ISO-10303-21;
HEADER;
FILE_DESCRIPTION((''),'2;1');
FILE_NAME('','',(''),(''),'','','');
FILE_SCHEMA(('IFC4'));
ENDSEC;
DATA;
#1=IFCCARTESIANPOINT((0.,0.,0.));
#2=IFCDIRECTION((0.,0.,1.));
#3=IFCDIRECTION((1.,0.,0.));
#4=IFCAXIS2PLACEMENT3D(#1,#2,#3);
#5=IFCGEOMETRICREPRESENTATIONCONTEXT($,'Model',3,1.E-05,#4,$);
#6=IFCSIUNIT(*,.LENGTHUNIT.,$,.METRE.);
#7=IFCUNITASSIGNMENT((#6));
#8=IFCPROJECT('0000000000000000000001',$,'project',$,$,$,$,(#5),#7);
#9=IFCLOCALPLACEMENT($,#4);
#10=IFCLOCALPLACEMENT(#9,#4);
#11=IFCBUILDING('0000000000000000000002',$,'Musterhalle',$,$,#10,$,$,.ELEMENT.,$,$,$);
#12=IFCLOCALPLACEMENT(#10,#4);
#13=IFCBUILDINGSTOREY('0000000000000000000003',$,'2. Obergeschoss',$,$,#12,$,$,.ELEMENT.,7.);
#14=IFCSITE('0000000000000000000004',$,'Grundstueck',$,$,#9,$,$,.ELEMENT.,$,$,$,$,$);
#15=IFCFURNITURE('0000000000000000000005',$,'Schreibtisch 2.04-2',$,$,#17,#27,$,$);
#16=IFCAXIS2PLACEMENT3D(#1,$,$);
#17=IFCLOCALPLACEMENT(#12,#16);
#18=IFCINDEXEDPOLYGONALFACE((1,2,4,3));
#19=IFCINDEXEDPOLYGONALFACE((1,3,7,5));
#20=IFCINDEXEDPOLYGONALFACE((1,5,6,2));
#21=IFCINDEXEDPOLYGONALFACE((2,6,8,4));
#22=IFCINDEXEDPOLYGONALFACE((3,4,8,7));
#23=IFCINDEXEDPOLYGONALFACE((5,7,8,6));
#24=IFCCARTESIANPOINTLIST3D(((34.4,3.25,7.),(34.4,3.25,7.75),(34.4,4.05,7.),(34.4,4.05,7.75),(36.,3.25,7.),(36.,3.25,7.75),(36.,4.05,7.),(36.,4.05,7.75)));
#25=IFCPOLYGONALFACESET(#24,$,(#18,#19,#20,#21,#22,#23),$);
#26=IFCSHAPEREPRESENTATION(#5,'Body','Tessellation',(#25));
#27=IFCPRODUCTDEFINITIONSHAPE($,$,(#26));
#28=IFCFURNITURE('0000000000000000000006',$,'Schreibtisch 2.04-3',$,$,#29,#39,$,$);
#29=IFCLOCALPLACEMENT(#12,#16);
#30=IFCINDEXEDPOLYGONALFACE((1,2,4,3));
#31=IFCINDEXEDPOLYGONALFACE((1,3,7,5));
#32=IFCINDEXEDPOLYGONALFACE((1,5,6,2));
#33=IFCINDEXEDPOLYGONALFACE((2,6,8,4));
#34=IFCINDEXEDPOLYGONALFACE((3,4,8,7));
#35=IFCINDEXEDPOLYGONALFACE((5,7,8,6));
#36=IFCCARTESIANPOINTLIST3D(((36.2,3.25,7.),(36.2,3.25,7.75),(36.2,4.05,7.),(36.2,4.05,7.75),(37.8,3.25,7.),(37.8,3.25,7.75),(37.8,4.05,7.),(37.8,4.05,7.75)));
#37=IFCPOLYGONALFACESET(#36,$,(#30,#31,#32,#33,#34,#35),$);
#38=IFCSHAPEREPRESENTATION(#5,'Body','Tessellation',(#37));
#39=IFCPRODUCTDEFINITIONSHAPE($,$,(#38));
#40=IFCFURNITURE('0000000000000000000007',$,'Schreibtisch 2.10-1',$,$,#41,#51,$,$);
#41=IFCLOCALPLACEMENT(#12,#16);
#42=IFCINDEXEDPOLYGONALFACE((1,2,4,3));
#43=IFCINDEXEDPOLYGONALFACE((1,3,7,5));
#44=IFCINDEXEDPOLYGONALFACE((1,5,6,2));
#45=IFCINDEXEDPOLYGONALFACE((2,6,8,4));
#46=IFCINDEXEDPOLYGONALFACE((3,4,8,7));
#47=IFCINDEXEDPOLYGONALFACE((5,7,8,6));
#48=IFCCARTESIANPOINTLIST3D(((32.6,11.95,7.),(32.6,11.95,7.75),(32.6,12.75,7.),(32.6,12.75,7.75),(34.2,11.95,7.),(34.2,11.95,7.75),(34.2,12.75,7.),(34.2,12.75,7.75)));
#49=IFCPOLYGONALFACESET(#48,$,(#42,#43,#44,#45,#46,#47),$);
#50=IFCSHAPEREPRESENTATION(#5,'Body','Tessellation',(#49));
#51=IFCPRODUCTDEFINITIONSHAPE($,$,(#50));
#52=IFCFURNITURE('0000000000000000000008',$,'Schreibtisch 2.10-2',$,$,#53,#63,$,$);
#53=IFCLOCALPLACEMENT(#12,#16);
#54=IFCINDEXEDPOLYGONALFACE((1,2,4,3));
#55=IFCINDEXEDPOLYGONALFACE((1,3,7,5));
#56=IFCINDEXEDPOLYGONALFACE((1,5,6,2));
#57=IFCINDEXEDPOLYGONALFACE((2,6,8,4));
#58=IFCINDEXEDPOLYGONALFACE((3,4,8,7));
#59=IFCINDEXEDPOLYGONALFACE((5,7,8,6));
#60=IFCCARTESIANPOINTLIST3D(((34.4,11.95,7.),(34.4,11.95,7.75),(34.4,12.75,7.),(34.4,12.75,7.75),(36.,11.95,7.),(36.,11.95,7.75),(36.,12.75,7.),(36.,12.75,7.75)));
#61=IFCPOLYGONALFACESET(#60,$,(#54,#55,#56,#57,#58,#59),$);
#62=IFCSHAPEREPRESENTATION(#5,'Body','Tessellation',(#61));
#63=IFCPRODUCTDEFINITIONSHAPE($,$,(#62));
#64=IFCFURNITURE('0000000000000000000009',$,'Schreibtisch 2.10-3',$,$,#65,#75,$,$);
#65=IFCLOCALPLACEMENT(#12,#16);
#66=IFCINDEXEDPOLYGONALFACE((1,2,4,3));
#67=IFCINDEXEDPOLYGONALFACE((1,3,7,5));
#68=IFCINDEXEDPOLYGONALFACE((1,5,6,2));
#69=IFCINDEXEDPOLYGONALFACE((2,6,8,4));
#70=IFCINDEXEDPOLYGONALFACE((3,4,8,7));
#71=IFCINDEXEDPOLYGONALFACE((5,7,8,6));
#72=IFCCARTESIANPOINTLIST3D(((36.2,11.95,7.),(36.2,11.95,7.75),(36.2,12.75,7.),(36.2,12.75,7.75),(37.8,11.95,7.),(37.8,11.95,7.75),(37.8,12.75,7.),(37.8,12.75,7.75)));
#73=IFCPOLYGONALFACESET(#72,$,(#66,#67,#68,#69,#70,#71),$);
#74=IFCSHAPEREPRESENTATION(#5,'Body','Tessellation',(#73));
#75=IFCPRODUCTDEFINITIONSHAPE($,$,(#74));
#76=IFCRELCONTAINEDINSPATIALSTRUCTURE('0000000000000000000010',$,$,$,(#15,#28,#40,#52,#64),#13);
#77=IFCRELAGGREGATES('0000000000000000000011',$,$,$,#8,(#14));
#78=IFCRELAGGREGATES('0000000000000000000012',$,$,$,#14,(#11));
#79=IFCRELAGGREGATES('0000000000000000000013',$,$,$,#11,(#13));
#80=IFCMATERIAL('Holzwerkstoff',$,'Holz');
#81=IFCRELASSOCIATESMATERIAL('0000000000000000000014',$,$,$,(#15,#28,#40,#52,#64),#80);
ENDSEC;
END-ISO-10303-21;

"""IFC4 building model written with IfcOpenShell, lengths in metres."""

from ifc_helpers import new_model, si_unit, frame, origin_with_axes, origin_2d, place, context, project, spatial, rectangle, extrude, material, element, save


model = new_model("IFC4")

# Units and contexts
model_context = context("Model", 3, precision=1e-05, world=origin_with_axes())
ifc_project = project(units=[si_unit("LENGTHUNIT", "METRE")], contexts=[model_context])

# Site, building, storey
site_placement = place(None, origin_with_axes())
site = spatial("IfcSite", under=ifc_project, at=site_placement, Name="Grundstueck", CompositionType="ELEMENT")
building_placement = place(site_placement, origin_with_axes())
building = spatial("IfcBuilding", under=site, at=building_placement, Name="Musterhalle", CompositionType="ELEMENT")
storey_placement = place(building_placement, origin_with_axes())
storey = spatial("IfcBuildingStorey", under=building, at=storey_placement, Name="2. Obergeschoss", CompositionType="ELEMENT", Elevation=7.0)

# Shared definitions
placement = place(storey_placement, origin_with_axes())

# Shared definitions
ifc_material_1 = material(Name="Holzwerkstoff", Category="Holz")

# Furniture
element("IfcFurniture", 1, at=placement, inside=storey, material=ifc_material_1, Name="Schreibtisch 2.04-2", context=model_context, shape_type="SweptSolid", body=[
    extrude(rectangle(XDim=1.6, YDim=0.8, at=origin_2d()), frame((35.2, 3.65, 7.0), z_axis=(0.0, 0.0, 1.0), x_axis=(1.0, 0.0, 0.0)), (0.0, 0.0, 1.0), 0.75),
])
element("IfcFurniture", 2, at=placement, inside=storey, material=ifc_material_1, Name="Schreibtisch 2.04-3", context=model_context, shape_type="SweptSolid", body=[
    extrude(rectangle(XDim=1.6, YDim=0.8, at=origin_2d()), frame((37.0, 3.65, 7.0), z_axis=(0.0, 0.0, 1.0), x_axis=(1.0, 0.0, 0.0)), (0.0, 0.0, 1.0), 0.75),
])
element("IfcFurniture", 3, at=placement, inside=storey, material=ifc_material_1, Name="Schreibtisch 2.10-1", context=model_context, shape_type="SweptSolid", body=[
    extrude(rectangle(XDim=1.6, YDim=0.8, at=origin_2d()), frame((33.4, 12.35, 7.0), z_axis=(0.0, 0.0, 1.0), x_axis=(1.0, 0.0, 0.0)), (0.0, 0.0, 1.0), 0.75),
])
element("IfcFurniture", 4, at=placement, inside=storey, material=ifc_material_1, Name="Schreibtisch 2.10-2", context=model_context, shape_type="SweptSolid", body=[
    extrude(rectangle(XDim=1.6, YDim=0.8, at=origin_2d()), frame((35.2, 12.35, 7.0), z_axis=(0.0, 0.0, 1.0), x_axis=(1.0, 0.0, 0.0)), (0.0, 0.0, 1.0), 0.75),
])
element("IfcFurniture", 5, at=placement, inside=storey, material=ifc_material_1, Name="Schreibtisch 2.10-3", context=model_context, shape_type="SweptSolid", body=[
    extrude(rectangle(XDim=1.6, YDim=0.8, at=origin_2d()), frame((37.0, 12.35, 7.0), z_axis=(0.0, 0.0, 1.0), x_axis=(1.0, 0.0, 0.0)), (0.0, 0.0, 1.0), 0.75),
])

save(model, "model.ifc")
